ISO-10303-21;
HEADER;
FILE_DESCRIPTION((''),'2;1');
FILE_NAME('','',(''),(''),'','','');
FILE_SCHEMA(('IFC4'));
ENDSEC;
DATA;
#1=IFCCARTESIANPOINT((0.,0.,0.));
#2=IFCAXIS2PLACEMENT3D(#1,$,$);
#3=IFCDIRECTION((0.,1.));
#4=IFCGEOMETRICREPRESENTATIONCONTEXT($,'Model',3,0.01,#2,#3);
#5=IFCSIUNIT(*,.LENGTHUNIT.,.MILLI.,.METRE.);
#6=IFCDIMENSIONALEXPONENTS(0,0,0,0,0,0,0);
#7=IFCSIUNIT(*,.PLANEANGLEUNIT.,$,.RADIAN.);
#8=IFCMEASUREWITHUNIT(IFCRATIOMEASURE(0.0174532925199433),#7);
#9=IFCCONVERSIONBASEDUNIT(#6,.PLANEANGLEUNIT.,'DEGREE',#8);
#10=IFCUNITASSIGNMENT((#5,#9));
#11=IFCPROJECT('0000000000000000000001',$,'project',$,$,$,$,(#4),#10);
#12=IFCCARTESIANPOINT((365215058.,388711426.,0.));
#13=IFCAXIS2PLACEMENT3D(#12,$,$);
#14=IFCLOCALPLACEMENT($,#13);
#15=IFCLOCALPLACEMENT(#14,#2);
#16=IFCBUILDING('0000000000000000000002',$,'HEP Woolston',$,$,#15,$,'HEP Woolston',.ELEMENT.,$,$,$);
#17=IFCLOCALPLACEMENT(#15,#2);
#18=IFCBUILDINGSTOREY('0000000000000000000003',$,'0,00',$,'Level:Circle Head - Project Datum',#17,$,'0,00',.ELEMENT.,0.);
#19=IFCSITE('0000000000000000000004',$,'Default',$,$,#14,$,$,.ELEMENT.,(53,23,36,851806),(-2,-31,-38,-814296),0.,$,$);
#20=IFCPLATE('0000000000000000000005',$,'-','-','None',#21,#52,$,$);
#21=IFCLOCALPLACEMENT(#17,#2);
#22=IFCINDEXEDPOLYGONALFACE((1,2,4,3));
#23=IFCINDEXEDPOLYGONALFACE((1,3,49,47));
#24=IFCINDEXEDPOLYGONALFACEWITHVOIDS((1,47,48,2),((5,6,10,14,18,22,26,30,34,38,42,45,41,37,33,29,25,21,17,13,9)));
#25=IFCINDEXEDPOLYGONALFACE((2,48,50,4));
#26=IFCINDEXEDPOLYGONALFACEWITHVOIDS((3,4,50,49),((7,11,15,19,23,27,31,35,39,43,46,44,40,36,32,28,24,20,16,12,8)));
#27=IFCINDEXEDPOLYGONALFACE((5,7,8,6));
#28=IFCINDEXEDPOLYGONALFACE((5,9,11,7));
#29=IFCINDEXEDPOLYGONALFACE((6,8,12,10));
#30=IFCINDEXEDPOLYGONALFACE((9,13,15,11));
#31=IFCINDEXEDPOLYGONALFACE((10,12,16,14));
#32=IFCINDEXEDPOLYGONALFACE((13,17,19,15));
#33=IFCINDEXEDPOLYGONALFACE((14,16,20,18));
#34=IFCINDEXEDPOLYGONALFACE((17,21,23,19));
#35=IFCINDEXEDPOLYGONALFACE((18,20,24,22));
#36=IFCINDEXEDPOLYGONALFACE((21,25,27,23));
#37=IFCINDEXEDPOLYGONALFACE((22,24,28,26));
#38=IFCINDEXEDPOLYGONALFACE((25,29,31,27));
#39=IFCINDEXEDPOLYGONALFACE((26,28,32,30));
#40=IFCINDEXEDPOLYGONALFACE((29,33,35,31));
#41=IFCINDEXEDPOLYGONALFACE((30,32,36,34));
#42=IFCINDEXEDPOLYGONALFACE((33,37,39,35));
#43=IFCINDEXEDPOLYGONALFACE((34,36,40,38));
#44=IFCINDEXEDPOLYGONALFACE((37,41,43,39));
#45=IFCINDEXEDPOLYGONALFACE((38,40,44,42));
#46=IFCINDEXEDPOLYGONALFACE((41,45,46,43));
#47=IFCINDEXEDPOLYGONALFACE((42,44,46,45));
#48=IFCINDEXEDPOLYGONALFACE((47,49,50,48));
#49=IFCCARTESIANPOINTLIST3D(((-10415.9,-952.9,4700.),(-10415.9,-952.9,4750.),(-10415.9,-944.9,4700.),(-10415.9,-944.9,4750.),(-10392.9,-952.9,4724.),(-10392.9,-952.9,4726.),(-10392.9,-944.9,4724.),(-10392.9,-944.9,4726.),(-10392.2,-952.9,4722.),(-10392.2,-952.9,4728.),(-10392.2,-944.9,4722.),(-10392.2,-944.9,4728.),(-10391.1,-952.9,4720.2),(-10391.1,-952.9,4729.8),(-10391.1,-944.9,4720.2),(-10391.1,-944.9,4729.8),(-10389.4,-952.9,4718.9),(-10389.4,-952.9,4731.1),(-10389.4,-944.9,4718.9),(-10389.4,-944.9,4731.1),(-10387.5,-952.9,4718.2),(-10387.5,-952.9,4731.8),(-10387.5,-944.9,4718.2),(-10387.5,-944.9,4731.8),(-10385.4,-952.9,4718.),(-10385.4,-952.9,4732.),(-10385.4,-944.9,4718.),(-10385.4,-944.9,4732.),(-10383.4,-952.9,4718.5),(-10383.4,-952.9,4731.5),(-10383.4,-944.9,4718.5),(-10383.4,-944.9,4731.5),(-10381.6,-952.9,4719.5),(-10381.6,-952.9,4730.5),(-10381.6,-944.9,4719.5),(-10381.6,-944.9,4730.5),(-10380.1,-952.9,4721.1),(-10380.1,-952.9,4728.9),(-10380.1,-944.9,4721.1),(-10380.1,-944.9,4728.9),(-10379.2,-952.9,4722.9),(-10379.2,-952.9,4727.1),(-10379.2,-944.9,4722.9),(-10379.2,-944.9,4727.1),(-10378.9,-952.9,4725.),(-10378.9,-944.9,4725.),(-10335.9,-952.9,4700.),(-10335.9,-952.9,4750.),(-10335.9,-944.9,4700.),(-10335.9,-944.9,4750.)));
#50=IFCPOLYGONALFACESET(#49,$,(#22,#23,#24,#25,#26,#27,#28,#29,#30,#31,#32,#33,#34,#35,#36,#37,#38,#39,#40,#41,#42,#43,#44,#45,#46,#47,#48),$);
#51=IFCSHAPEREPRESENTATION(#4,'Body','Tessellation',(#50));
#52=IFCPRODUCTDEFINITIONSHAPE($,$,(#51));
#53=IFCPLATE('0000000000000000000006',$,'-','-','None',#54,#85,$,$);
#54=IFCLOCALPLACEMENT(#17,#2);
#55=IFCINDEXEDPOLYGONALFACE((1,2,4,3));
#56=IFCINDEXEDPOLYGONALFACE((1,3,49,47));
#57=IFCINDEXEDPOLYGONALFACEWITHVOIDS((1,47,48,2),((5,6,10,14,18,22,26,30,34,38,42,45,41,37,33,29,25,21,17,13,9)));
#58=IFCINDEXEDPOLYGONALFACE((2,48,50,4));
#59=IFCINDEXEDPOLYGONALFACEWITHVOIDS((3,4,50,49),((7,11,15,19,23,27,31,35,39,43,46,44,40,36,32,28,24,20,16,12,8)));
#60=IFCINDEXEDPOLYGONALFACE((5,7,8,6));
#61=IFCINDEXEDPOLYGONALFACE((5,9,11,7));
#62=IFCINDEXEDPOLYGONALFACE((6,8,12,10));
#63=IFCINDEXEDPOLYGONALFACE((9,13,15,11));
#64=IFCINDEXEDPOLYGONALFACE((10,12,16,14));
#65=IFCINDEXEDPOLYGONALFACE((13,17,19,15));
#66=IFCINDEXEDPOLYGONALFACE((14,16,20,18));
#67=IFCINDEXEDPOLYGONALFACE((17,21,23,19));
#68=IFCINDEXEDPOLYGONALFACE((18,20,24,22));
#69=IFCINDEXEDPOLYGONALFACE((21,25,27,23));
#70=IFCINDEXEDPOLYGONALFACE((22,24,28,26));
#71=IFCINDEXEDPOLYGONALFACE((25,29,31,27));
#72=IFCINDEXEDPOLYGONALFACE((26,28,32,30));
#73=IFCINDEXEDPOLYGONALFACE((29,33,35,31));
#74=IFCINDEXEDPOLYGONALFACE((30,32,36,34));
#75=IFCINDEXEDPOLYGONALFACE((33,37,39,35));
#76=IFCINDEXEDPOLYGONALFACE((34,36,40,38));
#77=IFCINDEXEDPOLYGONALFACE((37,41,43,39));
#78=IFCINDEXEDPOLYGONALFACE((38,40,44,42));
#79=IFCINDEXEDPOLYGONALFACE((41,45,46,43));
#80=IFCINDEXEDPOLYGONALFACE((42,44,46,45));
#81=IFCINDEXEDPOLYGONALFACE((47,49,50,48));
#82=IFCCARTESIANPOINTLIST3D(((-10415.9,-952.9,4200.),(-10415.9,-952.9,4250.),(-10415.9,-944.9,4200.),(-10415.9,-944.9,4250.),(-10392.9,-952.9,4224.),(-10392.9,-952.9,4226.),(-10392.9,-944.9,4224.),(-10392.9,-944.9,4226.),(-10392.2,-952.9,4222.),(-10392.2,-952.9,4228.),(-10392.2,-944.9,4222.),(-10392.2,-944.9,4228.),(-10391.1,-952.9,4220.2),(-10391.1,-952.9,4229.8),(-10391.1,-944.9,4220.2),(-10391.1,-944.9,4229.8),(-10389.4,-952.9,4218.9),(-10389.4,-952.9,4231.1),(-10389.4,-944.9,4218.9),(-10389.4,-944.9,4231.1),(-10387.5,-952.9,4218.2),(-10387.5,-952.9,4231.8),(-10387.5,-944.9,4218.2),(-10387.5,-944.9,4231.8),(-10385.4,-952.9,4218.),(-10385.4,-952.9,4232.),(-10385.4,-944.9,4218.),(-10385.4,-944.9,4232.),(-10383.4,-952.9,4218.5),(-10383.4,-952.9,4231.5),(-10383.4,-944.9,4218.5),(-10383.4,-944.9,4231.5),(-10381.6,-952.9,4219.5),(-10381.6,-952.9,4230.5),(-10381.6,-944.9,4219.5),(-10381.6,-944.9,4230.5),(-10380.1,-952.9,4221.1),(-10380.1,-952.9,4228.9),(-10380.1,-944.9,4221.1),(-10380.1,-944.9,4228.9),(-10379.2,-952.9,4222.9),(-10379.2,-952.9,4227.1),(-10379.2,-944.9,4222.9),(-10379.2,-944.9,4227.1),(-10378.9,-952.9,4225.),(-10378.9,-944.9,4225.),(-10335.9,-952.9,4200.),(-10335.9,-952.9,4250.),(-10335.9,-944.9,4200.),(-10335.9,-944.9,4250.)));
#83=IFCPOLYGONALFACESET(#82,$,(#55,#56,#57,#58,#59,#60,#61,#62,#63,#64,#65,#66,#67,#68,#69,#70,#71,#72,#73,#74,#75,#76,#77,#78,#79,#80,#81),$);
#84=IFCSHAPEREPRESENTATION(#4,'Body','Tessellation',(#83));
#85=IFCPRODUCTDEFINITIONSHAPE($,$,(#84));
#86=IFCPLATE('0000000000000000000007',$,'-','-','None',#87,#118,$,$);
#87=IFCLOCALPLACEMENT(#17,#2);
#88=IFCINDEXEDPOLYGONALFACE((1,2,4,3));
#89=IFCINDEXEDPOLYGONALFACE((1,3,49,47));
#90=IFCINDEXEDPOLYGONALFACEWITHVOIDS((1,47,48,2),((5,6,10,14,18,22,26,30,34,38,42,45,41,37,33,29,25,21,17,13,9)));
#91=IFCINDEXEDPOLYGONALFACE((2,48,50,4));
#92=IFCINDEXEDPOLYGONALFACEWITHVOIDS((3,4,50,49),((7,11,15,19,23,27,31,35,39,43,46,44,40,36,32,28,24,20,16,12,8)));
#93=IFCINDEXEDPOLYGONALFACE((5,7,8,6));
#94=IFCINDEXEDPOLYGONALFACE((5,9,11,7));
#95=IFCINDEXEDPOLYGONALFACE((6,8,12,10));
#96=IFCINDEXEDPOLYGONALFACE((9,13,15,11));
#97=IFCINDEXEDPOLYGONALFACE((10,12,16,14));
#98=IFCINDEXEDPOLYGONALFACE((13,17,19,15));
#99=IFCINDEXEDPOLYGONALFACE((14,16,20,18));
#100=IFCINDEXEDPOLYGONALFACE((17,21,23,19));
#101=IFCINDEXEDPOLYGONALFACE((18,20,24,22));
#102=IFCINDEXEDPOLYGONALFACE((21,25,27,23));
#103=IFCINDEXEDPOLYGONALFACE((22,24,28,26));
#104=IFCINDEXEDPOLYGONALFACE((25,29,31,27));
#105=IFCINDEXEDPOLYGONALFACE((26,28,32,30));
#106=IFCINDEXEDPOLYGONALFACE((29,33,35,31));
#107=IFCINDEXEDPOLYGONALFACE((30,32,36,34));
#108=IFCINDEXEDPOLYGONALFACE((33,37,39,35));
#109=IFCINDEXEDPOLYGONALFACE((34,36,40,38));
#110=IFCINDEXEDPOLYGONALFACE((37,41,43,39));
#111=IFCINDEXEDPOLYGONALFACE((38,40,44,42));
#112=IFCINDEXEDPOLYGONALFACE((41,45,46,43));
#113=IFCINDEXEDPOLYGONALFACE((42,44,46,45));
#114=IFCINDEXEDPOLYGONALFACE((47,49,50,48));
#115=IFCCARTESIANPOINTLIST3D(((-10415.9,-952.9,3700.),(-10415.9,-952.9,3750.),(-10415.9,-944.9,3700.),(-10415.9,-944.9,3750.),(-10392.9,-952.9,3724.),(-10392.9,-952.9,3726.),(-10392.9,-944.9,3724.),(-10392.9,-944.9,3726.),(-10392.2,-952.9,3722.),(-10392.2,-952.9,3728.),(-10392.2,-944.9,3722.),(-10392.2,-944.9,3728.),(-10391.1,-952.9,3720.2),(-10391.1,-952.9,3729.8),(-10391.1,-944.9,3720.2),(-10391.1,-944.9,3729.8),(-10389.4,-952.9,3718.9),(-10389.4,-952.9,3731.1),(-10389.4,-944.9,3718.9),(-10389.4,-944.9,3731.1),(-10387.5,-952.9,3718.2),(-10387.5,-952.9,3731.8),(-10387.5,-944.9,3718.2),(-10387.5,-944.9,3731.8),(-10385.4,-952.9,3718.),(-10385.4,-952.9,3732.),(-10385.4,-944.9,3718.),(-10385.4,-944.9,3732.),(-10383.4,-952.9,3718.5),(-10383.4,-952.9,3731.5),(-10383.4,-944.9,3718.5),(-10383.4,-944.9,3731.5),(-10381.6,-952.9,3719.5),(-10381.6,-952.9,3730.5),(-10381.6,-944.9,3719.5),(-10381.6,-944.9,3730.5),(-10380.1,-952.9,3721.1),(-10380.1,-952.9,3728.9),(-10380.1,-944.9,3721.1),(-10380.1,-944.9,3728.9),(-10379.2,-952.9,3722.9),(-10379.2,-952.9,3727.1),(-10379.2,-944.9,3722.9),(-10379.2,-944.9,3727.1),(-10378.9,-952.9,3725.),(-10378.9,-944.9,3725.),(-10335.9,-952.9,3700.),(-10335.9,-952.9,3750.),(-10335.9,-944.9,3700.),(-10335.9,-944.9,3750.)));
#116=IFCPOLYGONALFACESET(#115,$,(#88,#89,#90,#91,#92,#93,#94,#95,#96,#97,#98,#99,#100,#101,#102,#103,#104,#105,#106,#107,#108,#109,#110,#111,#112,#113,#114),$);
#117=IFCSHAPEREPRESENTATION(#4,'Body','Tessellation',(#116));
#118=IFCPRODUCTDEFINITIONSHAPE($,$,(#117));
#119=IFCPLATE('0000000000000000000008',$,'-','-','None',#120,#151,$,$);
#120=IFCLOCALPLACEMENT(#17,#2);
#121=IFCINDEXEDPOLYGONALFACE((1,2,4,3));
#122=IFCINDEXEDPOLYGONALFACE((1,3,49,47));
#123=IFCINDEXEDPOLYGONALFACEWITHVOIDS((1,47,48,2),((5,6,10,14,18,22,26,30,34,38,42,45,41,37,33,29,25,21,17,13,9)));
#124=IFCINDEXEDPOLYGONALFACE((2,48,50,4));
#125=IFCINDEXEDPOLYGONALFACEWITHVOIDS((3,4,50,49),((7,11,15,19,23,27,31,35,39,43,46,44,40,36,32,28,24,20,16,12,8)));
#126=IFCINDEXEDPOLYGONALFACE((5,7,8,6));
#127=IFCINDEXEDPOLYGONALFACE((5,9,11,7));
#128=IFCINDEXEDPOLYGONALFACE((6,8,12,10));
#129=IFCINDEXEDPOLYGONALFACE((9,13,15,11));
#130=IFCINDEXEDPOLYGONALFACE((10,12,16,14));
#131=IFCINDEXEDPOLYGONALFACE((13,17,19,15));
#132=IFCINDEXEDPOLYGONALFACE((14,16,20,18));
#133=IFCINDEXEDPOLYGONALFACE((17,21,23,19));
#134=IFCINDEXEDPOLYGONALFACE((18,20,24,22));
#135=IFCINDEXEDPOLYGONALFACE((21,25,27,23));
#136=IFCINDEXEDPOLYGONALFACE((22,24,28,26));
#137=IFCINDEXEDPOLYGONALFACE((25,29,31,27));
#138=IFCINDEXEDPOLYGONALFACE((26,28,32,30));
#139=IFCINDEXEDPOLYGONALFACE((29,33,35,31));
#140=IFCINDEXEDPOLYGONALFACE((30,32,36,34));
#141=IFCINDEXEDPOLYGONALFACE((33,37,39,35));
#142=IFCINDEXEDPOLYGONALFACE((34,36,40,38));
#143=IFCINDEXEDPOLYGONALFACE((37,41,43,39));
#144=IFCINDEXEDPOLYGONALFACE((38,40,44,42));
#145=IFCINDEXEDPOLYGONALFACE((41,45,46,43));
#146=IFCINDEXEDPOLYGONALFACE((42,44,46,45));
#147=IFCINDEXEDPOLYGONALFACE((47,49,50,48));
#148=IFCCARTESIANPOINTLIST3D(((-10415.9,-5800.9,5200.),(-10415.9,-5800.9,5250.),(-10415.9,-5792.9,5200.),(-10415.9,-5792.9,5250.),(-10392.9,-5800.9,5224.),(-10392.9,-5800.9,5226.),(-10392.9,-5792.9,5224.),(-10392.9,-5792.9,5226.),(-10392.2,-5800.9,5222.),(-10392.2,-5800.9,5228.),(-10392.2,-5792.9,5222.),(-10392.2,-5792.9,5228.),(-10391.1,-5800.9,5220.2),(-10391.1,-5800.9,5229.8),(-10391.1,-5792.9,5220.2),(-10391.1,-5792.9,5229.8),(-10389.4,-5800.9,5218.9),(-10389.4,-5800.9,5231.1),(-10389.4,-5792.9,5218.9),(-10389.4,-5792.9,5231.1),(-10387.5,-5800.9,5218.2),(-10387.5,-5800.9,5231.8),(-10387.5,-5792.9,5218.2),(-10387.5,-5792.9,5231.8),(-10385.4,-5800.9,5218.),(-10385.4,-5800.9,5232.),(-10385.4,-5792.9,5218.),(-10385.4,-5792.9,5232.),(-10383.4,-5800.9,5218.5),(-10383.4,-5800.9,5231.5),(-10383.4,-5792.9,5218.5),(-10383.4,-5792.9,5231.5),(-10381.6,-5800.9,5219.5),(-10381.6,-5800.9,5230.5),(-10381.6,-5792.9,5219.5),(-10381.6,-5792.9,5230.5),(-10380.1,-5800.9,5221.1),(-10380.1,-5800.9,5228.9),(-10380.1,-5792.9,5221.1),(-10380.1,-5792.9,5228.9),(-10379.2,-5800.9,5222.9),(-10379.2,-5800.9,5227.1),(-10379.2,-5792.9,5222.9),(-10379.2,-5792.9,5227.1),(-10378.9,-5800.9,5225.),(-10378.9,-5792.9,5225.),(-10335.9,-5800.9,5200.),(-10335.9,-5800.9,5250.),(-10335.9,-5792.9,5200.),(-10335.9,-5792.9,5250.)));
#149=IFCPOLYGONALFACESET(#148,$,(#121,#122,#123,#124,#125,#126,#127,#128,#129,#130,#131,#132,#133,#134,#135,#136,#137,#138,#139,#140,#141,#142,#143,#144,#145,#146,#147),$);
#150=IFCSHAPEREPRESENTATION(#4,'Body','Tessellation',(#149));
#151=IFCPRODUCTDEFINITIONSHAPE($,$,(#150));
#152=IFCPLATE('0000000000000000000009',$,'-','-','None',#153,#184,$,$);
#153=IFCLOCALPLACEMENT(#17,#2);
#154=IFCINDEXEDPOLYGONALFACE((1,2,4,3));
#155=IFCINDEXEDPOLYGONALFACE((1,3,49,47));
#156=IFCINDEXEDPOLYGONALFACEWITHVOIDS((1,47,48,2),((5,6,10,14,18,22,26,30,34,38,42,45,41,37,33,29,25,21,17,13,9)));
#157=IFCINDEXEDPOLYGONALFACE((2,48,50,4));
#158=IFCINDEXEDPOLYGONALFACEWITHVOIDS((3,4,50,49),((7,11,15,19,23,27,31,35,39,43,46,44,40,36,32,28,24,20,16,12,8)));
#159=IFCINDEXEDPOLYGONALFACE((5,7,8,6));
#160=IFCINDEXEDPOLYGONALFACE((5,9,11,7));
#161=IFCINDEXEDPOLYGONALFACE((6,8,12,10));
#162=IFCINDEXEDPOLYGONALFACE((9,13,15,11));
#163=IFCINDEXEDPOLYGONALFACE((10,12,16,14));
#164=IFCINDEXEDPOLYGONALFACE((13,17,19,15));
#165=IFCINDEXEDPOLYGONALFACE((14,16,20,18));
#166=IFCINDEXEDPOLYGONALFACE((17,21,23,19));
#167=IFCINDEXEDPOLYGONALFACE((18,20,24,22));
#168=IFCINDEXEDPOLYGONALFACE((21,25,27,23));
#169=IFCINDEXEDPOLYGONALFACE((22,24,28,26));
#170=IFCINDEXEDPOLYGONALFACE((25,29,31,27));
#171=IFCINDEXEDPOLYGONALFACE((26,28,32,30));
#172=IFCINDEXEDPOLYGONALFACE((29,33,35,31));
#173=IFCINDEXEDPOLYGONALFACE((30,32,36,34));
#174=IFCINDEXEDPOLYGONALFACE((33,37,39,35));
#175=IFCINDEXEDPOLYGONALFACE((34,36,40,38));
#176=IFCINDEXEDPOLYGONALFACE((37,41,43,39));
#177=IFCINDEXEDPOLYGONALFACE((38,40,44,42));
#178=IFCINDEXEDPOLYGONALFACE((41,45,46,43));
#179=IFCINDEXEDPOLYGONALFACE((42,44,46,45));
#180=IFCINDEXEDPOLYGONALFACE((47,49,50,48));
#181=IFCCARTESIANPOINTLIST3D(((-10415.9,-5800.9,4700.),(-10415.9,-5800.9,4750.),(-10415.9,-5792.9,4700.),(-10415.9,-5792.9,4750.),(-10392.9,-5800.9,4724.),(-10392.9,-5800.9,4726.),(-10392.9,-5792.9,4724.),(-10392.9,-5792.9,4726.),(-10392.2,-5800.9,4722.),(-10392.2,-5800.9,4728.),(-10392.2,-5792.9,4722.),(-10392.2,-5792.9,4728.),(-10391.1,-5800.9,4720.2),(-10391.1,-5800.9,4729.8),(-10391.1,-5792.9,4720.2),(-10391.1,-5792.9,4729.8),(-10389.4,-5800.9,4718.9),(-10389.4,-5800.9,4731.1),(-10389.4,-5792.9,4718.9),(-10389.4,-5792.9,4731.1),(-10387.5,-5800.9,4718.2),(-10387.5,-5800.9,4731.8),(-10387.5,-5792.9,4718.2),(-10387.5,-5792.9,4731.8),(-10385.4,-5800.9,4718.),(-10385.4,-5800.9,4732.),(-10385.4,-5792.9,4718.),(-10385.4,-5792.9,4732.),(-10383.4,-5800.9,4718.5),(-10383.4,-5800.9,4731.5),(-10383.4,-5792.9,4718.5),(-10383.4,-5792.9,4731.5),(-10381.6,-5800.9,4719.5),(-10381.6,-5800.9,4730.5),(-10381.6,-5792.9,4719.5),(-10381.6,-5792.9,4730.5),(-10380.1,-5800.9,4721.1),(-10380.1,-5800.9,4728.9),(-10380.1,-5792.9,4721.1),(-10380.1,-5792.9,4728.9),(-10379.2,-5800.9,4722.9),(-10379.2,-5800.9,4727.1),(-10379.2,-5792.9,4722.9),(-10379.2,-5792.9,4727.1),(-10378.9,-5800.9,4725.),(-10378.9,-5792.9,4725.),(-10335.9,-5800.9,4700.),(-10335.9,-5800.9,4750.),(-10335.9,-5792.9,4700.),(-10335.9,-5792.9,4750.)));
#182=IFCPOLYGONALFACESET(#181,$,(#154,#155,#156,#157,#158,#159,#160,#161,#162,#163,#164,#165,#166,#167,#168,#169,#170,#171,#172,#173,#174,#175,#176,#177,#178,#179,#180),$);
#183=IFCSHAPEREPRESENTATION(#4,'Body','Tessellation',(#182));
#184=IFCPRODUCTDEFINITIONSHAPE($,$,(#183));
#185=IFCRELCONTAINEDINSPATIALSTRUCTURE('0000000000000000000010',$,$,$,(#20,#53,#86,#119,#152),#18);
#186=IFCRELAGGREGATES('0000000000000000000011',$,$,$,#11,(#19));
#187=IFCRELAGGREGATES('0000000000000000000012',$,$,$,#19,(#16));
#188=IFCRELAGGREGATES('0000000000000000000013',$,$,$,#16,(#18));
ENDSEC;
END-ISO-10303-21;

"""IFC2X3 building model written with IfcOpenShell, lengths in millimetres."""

from ifc_helpers import new_model, entity, si_unit, converted_unit, direction, frame, frame_2d, origin, origin_with_axes, origin_2d_with_axis, place, context, project, spatial, polyline, circle, outline, extrude, element, save


model = new_model("IFC2X3")

# Units and contexts
model_context = context("Model", 3, precision=0.01, world=origin(), true_north=direction((0.0, 1.0)))
ifc_project = project(units=[si_unit("LENGTHUNIT", "METRE", prefix="MILLI"), converted_unit("PLANEANGLEUNIT", "DEGREE", entity("IfcRatioMeasure", 0.0174532925199433), si_unit("PLANEANGLEUNIT", "RADIAN"), dimensions=[0, 0, 0, 0, 0, 0, 0])], contexts=[model_context])

# Site, building, storey
site_placement = place(None, frame((365215058.0, 388711426.0, 0.0)))
site = spatial("IfcSite", under=ifc_project, at=site_placement, Name="Default", CompositionType="ELEMENT", RefLatitude=(53, 23, 36, 851806), RefLongitude=(-2, -31, -38, -814296), RefElevation=0.0)
building_placement = place(site_placement, origin())
building = spatial("IfcBuilding", under=site, at=building_placement, Name="HEP Woolston", LongName="HEP Woolston", CompositionType="ELEMENT")
storey_placement = place(building_placement, origin())
storey = spatial("IfcBuildingStorey", under=building, at=storey_placement, Name="0,00", ObjectType="Level:Circle Head - Project Datum", LongName="0,00", CompositionType="ELEMENT", Elevation=0.0)

# Plates, openings
plate_1_placement = place(storey_placement, frame((-10335.9, -952.9, 4750.0), z_axis=(0.0, 1.0, 0.0), x_axis=(-1.0, 0.0, 0.0)))
plate_1 = element("IfcPlate", 1, at=plate_1_placement, inside=storey, Name="-", Description="-", ObjectType="None", context=model_context, shape_type="SweptSolid", body=[
    extrude(outline(polyline([(0.0, 0.0), (0.0, -50.0), (80.0, -50.0), (80.0, 0.0), (0.0, 0.0)])), origin_with_axes(), (0.0, 0.0, 1.0), 8.0),
])
opening_1_placement = place(plate_1_placement, frame((50.0, -25.0, 8.5), z_axis=(0.0, 0.0, -1.0), x_axis=(-1.0, 0.0, 0.0)))
element("IfcOpeningElement", 2, at=opening_1_placement, cuts=plate_1, ObjectType="Opening", context=model_context, shape_type="SweptSolid", body=[
    extrude(circle(Radius=7.0, at=origin_2d_with_axis()), origin(), (0.0, 0.0, 1.0), 9.0),
])
plate_2_placement = place(storey_placement, frame((-10335.9, -952.9, 4250.0), z_axis=(0.0, 1.0, 0.0), x_axis=(-1.0, 0.0, 0.0)))
plate_2 = element("IfcPlate", 3, at=plate_2_placement, inside=storey, Name="-", Description="-", ObjectType="None", context=model_context, shape_type="SweptSolid", body=[
    extrude(outline(polyline([(0.0, 0.0), (0.0, -50.0), (80.0, -50.0), (80.0, 0.0), (0.0, 0.0)])), origin_with_axes(), (0.0, 0.0, 1.0), 8.0),
])
opening_2_placement = place(plate_2_placement, frame((50.0, -25.0, 8.5), z_axis=(0.0, 0.0, -1.0), x_axis=(-1.0, 0.0, 0.0)))
element("IfcOpeningElement", 4, at=opening_2_placement, cuts=plate_2, ObjectType="Opening", context=model_context, shape_type="SweptSolid", body=[
    extrude(circle(Radius=7.0, at=origin_2d_with_axis()), origin(), (0.0, 0.0, 1.0), 9.0),
])
plate_3_placement = place(storey_placement, frame((-10335.9, -952.9, 3750.0), z_axis=(0.0, 1.0, 0.0), x_axis=(-1.0, 0.0, 0.0)))
plate_3 = element("IfcPlate", 5, at=plate_3_placement, inside=storey, Name="-", Description="-", ObjectType="None", context=model_context, shape_type="SweptSolid", body=[
    extrude(outline(polyline([(0.0, 0.0), (0.0, -50.0), (80.0, -50.0), (80.0, 0.0), (0.0, 0.0)])), origin_with_axes(), (0.0, 0.0, 1.0), 8.0),
])
opening_3_placement = place(plate_3_placement, frame((50.0, -25.0, 8.5), z_axis=(0.0, 0.0, -1.0), x_axis=(-1.0, 0.0, 0.0)))
element("IfcOpeningElement", 6, at=opening_3_placement, cuts=plate_3, ObjectType="Opening", context=model_context, shape_type="SweptSolid", body=[
    extrude(circle(Radius=7.0, at=origin_2d_with_axis()), origin(), (0.0, 0.0, 1.0), 9.0),
])
plate_4_placement = place(storey_placement, frame((-10335.9, -5792.9, 5250.0), z_axis=(0.0, 1.0, 0.0), x_axis=(-1.0, 0.0, 0.0)))
plate_4 = element("IfcPlate", 7, at=plate_4_placement, inside=storey, Name="-", Description="-", ObjectType="None", context=model_context, shape_type="SweptSolid", body=[
    extrude(outline(polyline([(0.0, 0.0), (0.0, -50.0), (80.0, -50.0), (80.0, 0.0), (0.0, 0.0)])), origin_with_axes(), (0.0, 0.0, -1.0), 8.0),
])
opening_4_placement = place(plate_4_placement, frame((57.0, -25.0, -8.5), z_axis=(0.0, 0.0, -1.0), x_axis=(-1.0, 0.0, 0.0)))
element("IfcOpeningElement", 8, at=opening_4_placement, cuts=plate_4, ObjectType="Opening", context=model_context, shape_type="SweptSolid", body=[
    extrude(circle(Radius=7.0, at=frame_2d((7.0, 0.0), x_axis=(1.0, 0.0))), origin(), (0.0, 0.0, -1.0), 9.0),
])
plate_5_placement = place(storey_placement, frame((-10335.9, -5792.9, 4750.0), z_axis=(0.0, 1.0, 0.0), x_axis=(-1.0, 0.0, 0.0)))
plate_5 = element("IfcPlate", 9, at=plate_5_placement, inside=storey, Name="-", Description="-", ObjectType="None", context=model_context, shape_type="SweptSolid", body=[
    extrude(outline(polyline([(0.0, 0.0), (0.0, -50.0), (80.0, -50.0), (80.0, 0.0), (0.0, 0.0)])), origin_with_axes(), (0.0, 0.0, -1.0), 8.0),
])
opening_5_placement = place(plate_5_placement, frame((57.0, -25.0, -8.5), z_axis=(0.0, 0.0, -1.0), x_axis=(-1.0, 0.0, 0.0)))
element("IfcOpeningElement", 10, at=opening_5_placement, cuts=plate_5, ObjectType="Opening", context=model_context, shape_type="SweptSolid", body=[
    extrude(circle(Radius=7.0, at=frame_2d((7.0, 0.0), x_axis=(1.0, 0.0))), origin(), (0.0, 0.0, -1.0), 9.0),
])

save(model, "model.ifc")
